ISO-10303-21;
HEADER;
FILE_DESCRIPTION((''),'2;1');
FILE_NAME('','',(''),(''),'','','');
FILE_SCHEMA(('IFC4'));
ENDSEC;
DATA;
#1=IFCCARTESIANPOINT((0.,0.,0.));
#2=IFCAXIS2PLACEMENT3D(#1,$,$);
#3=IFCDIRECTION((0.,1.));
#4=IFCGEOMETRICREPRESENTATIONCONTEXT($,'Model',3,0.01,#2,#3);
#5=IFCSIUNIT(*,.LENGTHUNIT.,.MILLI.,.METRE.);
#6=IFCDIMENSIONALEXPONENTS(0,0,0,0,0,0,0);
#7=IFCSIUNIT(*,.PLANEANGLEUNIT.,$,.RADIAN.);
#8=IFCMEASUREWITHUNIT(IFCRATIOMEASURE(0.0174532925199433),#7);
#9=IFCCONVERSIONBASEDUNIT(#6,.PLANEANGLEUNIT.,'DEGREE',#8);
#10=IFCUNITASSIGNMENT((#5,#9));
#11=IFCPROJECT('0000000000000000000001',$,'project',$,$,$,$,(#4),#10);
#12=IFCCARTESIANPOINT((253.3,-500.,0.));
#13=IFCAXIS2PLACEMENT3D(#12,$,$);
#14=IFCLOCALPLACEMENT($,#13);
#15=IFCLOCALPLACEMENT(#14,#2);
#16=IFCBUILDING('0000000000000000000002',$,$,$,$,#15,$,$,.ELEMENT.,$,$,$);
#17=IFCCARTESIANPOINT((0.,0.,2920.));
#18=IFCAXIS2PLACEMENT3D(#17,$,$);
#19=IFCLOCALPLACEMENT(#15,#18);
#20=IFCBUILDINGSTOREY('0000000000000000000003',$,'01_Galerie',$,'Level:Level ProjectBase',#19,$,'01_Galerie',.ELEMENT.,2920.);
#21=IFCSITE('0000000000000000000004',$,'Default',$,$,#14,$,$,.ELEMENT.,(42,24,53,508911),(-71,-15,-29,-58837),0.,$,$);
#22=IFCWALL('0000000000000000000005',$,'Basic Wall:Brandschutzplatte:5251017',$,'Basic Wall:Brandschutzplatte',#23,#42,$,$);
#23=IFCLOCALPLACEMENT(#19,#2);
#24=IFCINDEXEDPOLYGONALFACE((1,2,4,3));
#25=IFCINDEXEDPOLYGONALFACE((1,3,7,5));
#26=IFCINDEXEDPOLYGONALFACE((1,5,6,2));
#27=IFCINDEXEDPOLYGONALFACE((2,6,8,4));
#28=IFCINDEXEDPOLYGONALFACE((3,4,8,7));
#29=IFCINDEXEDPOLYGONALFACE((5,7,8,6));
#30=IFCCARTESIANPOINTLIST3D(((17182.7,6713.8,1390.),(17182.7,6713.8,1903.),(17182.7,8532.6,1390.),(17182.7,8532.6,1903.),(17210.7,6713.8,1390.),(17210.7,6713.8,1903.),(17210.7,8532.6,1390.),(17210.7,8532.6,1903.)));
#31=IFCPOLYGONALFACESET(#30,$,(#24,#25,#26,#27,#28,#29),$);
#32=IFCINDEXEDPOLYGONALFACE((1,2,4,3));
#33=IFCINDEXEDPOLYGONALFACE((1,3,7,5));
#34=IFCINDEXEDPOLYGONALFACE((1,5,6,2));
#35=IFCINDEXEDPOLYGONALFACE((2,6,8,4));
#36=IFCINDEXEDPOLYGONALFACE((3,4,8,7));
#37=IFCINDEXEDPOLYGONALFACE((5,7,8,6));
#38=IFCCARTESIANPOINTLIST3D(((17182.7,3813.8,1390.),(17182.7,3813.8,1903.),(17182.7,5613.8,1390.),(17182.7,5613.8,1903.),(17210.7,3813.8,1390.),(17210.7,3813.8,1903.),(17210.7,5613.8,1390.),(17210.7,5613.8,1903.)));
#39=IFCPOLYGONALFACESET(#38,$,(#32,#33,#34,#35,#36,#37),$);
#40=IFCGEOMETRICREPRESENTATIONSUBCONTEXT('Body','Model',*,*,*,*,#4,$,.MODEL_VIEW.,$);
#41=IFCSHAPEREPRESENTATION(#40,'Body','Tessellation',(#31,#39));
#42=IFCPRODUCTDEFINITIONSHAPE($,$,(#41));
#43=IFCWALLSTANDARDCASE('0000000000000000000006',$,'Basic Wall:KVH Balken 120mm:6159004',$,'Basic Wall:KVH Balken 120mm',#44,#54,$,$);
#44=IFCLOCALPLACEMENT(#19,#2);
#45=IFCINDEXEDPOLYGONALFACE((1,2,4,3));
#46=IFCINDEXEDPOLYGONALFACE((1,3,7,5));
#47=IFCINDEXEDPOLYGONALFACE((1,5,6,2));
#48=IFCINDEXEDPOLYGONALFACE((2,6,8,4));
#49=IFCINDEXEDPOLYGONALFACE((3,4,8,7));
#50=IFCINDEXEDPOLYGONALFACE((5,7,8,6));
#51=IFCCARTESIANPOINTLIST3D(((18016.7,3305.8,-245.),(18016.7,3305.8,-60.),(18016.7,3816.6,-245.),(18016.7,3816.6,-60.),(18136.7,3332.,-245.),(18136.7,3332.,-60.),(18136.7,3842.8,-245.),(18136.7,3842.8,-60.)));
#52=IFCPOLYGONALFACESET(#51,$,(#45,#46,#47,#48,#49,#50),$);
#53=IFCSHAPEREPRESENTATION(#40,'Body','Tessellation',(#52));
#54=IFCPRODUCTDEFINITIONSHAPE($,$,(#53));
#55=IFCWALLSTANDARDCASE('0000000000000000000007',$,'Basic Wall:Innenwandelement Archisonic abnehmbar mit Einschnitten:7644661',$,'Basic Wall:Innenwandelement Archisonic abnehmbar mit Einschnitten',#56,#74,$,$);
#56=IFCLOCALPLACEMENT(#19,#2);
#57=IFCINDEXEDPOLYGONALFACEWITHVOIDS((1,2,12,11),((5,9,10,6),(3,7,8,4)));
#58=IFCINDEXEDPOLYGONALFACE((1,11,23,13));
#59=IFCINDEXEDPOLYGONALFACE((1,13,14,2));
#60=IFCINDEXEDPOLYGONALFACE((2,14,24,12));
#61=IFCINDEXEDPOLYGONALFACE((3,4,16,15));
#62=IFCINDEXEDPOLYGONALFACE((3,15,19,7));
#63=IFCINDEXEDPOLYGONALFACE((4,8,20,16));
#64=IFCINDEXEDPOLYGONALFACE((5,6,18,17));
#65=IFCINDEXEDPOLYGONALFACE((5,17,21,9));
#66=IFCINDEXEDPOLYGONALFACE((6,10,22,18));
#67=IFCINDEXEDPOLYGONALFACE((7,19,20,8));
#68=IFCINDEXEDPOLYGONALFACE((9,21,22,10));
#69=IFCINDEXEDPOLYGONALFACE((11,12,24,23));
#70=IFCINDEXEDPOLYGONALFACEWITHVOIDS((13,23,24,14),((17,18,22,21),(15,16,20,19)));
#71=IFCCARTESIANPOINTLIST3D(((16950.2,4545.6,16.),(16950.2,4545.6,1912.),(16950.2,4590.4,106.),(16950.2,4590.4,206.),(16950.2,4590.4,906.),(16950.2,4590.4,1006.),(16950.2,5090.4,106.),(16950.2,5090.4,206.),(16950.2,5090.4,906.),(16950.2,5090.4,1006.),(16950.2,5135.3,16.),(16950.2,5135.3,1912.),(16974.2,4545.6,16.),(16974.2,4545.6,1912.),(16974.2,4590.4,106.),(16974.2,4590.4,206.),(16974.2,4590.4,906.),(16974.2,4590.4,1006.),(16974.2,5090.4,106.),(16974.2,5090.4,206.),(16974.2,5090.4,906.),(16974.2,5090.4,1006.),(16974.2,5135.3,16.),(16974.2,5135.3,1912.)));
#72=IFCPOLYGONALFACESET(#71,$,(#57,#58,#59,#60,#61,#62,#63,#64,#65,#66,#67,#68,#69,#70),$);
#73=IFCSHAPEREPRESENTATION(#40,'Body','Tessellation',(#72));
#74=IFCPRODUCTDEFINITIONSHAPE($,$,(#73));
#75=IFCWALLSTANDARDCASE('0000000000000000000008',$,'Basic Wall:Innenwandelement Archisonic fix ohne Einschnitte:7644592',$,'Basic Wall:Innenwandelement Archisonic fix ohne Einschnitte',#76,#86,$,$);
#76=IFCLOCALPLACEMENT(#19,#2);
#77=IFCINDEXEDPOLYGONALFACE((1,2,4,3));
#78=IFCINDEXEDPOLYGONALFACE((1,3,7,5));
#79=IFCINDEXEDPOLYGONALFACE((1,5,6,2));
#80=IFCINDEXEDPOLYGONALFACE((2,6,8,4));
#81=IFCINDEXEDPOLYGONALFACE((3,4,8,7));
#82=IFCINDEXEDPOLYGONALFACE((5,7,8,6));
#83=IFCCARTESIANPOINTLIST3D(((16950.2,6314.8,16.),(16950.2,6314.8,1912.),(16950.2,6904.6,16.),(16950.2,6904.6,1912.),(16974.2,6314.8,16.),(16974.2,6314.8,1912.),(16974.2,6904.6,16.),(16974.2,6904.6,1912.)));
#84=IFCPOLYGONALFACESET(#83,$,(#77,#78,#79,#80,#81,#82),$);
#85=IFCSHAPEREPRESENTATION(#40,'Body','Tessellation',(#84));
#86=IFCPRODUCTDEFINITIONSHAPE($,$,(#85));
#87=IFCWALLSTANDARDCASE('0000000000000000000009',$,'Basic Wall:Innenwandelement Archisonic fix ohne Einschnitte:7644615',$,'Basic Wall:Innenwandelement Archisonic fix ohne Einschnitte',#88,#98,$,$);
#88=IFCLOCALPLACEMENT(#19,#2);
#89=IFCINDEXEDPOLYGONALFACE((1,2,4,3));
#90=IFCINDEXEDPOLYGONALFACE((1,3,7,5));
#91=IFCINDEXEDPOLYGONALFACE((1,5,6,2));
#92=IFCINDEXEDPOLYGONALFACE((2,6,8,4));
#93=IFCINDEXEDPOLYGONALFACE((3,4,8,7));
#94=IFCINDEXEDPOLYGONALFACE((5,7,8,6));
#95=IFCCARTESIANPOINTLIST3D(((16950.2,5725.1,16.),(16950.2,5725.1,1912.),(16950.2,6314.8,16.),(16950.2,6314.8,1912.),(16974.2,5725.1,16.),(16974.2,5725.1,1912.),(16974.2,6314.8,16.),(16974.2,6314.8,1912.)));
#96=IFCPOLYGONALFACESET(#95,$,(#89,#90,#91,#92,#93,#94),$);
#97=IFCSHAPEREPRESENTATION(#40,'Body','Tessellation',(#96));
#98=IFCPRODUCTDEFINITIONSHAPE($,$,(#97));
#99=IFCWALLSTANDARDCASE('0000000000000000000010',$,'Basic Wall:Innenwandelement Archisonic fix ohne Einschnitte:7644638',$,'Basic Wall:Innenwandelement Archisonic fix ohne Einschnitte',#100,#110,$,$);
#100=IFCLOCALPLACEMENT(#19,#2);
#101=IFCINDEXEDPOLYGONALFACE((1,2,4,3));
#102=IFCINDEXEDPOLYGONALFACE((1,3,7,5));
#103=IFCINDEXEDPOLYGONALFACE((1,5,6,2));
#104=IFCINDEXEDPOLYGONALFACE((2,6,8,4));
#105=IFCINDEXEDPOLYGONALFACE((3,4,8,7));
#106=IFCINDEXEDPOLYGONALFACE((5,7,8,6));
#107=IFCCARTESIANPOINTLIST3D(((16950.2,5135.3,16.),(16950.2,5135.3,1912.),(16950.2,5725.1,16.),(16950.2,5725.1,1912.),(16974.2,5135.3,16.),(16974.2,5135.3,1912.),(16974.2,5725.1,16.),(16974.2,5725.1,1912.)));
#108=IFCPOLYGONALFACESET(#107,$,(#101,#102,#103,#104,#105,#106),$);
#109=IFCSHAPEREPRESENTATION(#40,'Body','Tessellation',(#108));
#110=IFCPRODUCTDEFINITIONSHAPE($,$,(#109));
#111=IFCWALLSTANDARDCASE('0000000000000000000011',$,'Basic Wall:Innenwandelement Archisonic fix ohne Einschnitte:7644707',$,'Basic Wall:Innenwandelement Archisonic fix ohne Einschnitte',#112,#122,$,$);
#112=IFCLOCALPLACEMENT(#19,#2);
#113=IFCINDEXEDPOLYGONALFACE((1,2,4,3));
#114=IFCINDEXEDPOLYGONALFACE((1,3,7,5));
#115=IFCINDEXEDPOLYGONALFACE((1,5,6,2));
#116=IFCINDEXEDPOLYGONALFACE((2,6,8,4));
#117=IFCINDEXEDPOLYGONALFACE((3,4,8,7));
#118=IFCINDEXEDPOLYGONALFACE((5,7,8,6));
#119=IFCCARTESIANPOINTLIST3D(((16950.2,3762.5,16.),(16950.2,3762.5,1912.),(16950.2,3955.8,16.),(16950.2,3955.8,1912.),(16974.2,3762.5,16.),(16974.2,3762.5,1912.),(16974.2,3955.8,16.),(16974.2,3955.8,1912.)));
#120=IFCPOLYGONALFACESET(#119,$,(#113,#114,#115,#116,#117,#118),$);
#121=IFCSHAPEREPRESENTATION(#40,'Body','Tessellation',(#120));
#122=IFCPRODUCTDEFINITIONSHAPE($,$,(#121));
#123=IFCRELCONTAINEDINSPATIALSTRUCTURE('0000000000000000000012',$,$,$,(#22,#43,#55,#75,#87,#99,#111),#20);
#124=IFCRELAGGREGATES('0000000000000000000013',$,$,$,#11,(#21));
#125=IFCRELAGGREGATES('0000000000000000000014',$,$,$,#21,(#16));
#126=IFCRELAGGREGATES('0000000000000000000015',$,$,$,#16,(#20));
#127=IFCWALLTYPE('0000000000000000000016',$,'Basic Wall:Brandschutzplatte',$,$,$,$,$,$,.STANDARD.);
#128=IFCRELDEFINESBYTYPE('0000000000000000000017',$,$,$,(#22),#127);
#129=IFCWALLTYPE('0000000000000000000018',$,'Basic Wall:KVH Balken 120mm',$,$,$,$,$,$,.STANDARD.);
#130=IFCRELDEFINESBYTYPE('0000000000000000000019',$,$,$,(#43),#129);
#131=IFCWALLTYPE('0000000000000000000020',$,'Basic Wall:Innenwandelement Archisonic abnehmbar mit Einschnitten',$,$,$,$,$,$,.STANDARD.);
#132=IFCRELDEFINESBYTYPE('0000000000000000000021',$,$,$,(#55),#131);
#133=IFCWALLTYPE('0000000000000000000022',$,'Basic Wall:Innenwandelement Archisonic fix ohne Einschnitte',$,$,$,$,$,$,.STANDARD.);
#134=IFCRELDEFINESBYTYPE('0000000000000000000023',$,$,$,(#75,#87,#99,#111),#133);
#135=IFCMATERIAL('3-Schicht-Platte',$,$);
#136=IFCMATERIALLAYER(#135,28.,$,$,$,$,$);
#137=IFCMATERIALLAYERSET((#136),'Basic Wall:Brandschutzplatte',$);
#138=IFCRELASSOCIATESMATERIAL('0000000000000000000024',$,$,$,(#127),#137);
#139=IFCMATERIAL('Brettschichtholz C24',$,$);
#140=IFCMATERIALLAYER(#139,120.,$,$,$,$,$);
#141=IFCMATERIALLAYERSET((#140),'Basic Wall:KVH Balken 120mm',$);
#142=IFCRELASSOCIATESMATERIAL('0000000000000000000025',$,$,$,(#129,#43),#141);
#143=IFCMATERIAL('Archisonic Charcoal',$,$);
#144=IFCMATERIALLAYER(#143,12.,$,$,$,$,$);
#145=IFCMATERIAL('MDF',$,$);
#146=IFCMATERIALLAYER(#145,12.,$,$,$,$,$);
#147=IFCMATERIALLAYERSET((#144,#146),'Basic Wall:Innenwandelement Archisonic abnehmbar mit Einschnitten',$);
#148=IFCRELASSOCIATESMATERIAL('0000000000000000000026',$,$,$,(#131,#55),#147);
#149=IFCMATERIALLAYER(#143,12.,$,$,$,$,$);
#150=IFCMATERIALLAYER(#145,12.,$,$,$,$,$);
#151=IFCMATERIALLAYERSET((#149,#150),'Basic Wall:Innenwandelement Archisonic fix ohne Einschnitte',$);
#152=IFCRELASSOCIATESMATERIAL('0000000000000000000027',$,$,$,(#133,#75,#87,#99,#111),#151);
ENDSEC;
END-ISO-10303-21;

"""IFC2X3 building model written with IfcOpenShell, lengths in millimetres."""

from ifc_helpers import new_model, entity, si_unit, converted_unit, direction, frame, frame_2d, origin, place, context, subcontext, project, spatial, polyline, rectangle, outline, extrude, clip, bounded_halfspace, material, layer, layer_set, layer_usage, type_object, element, save


model = new_model("IFC2X3")

# Units and contexts
model_context = context("Model", 3, precision=0.01, world=origin(), true_north=direction((0.0, 1.0)))
body_context = subcontext(model_context, "Body", "Model", "MODEL_VIEW")
ifc_project = project(units=[si_unit("LENGTHUNIT", "METRE", prefix="MILLI"), converted_unit("PLANEANGLEUNIT", "DEGREE", entity("IfcRatioMeasure", 0.0174532925199433), si_unit("PLANEANGLEUNIT", "RADIAN"), dimensions=[0, 0, 0, 0, 0, 0, 0])], contexts=[model_context])

# Site, building, storey
site_placement = place(None, frame((253.3, -500.0, 0.0)))
site = spatial("IfcSite", under=ifc_project, at=site_placement, Name="Default", CompositionType="ELEMENT", RefLatitude=(42, 24, 53, 508911), RefLongitude=(-71, -15, -29, -58837), RefElevation=0.0)
building_placement = place(site_placement, origin())
building = spatial("IfcBuilding", under=site, at=building_placement, CompositionType="ELEMENT")
storey_placement = place(building_placement, frame((0.0, 0.0, 2920.0)))
storey = spatial("IfcBuildingStorey", under=building, at=storey_placement, Name="01_Galerie", ObjectType="Level:Level ProjectBase", LongName="01_Galerie", CompositionType="ELEMENT", Elevation=2920.0)

# Shared definitions
ifc_material_1 = material(Name="Archisonic Charcoal")
ifc_material_2 = material(Name="MDF")
ifc_material_3 = material(Name="Brettschichtholz C24")

# Walls
ifc_material_4 = material(Name="3-Schicht-Platte")
ifc_layer_1 = layer(ifc_material_4, 28.0)
ifc_layer_set_1 = layer_set([ifc_layer_1], Name="Basic Wall:Brandschutzplatte")
wall_type_1 = type_object("IfcWallType", Name="Basic Wall:Brandschutzplatte", PredefinedType="STANDARD", material=ifc_layer_set_1)
wall_1_placement = place(storey_placement, frame((17196.7, 3813.8, 1390.0), z_axis=(0.0, 0.0, 1.0), x_axis=(0.0, 1.0, 0.0)))
element("IfcWall", 1, at=wall_1_placement, inside=storey, type_object=wall_type_1, Name="Basic Wall:Brandschutzplatte:5251017", ObjectType="Basic Wall:Brandschutzplatte", context=body_context, shape_type="SweptSolid", body=[
    extrude(rectangle(XDim=28.0, YDim=1818.8, at=frame_2d((0.0, 0.0), x_axis=(1.0, 0.0))), frame((3809.4, 0.0, 0.0), z_axis=(0.0, 0.0, 1.0), x_axis=(0.0, 1.0, 0.0)), (0.0, 0.0, 1.0), 513.0),
    extrude(rectangle(XDim=28.0, YDim=1800.0, at=frame_2d((0.0, 0.0), x_axis=(1.0, 0.0))), frame((900.0, 0.0, 0.0), z_axis=(0.0, 0.0, 1.0), x_axis=(0.0, 1.0, 0.0)), (0.0, 0.0, 1.0), 513.0),
])
ifc_layer_2 = layer(ifc_material_3, 120.0)
ifc_layer_set_2 = layer_set([ifc_layer_2], Name="Basic Wall:KVH Balken 120mm")
ifc_layer_usage_1 = layer_usage(ifc_layer_set_2, "AXIS2", "NEGATIVE", 60.0)
wall_type_2 = type_object("IfcWallType", Name="Basic Wall:KVH Balken 120mm", PredefinedType="STANDARD", material=ifc_layer_set_2)
wall_2_placement = place(storey_placement, frame((18076.7, 3305.8, -245.0), z_axis=(0.0, 0.0, 1.0), x_axis=(0.0, 1.0, 0.0)))
element("IfcWallStandardCase", 2, at=wall_2_placement, inside=storey, type_object=wall_type_2, material=ifc_layer_usage_1, Name="Basic Wall:KVH Balken 120mm:6159004", ObjectType="Basic Wall:KVH Balken 120mm", context=body_context, shape_type="Clipping", body=[
    clip(extrude(outline(polyline([(537.0, -60.0), (510.8, 60.0), (0.0, 60.0), (26.2, -60.0), (537.0, -60.0)])), origin(), (0.0, 0.0, 1.0), 185.0), bounded_halfspace(frame((537.0, -60.0, 185.0), z_axis=(-0.977008, -0.213201, 0.0), x_axis=(0.213201, -0.977008, 0.0)), True, frame((537.0, -60.0, 185.0), z_axis=(-0.977008, -0.213201, 0.0), x_axis=(0.213201, -0.977008, 0.0)), polyline([(0.0, 0.0), (-122.8, 0.0), (-122.8, -185.0), (0.0, -185.0), (0.0, 0.0)]))),
])

# Wall, openings
ifc_layer_3 = layer(ifc_material_1, 12.0)
ifc_layer_4 = layer(ifc_material_2, 12.0)
ifc_layer_set_3 = layer_set([ifc_layer_3, ifc_layer_4], Name="Basic Wall:Innenwandelement Archisonic abnehmbar mit Einschnitten")
ifc_layer_usage_2 = layer_usage(ifc_layer_set_3, "AXIS2", "POSITIVE", -12.0)
wall_type_3 = type_object("IfcWallType", Name="Basic Wall:Innenwandelement Archisonic abnehmbar mit Einschnitten", PredefinedType="STANDARD", material=ifc_layer_set_3)
wall_3_placement = place(storey_placement, frame((16962.2, 5135.3, 16.0), z_axis=(0.0, 0.0, 1.0), x_axis=(0.0, -1.0, 0.0)))
wall_3 = element("IfcWallStandardCase", 3, at=wall_3_placement, inside=storey, type_object=wall_type_3, material=ifc_layer_usage_2, Name="Basic Wall:Innenwandelement Archisonic abnehmbar mit Einschnitten:7644661", ObjectType="Basic Wall:Innenwandelement Archisonic abnehmbar mit Einschnitten", context=body_context, shape_type="SweptSolid", body=[
    extrude(rectangle(XDim=589.8, YDim=24.0, at=frame_2d((294.9, 0.0), x_axis=(-1.0, 0.0))), origin(), (0.0, 0.0, 1.0), 1896.0),
])
opening_1_placement = place(wall_3_placement, frame((544.9, -45.8, 890.0)))
element("IfcOpeningElement", 4, at=opening_1_placement, cuts=wall_3, ObjectType="Opening", context=body_context, shape_type="SweptSolid", body=[
    extrude(rectangle(XDim=100.0, YDim=500.0, at=frame_2d((0.0, 0.0), x_axis=(0.0, 1.0))), frame((-250.0, 0.0, 50.0), z_axis=(0.0, 1.0, 0.0), x_axis=(-1.0, 0.0, 0.0)), (0.0, 0.0, 1.0), 336.7),
])
opening_2_placement = place(wall_3_placement, frame((544.9, -45.8, 90.0)))
element("IfcOpeningElement", 5, at=opening_2_placement, cuts=wall_3, ObjectType="Opening", context=body_context, shape_type="SweptSolid", body=[
    extrude(rectangle(XDim=100.0, YDim=500.0, at=frame_2d((0.0, 0.0), x_axis=(0.0, 1.0))), frame((-250.0, 0.0, 50.0), z_axis=(0.0, 1.0, 0.0), x_axis=(-1.0, 0.0, 0.0)), (0.0, 0.0, 1.0), 136.7),
])

# Walls
ifc_layer_5 = layer(ifc_material_1, 12.0)
ifc_layer_6 = layer(ifc_material_2, 12.0)
ifc_layer_set_4 = layer_set([ifc_layer_5, ifc_layer_6], Name="Basic Wall:Innenwandelement Archisonic fix ohne Einschnitte")
ifc_layer_usage_3 = layer_usage(ifc_layer_set_4, "AXIS2", "POSITIVE", -12.0)
wall_type_4 = type_object("IfcWallType", Name="Basic Wall:Innenwandelement Archisonic fix ohne Einschnitte", PredefinedType="STANDARD", material=ifc_layer_set_4)
wall_4_placement = place(storey_placement, frame((16962.2, 6904.6, 16.0), z_axis=(0.0, 0.0, 1.0), x_axis=(0.0, -1.0, 0.0)))
element("IfcWallStandardCase", 6, at=wall_4_placement, inside=storey, type_object=wall_type_4, material=ifc_layer_usage_3, Name="Basic Wall:Innenwandelement Archisonic fix ohne Einschnitte:7644592", ObjectType="Basic Wall:Innenwandelement Archisonic fix ohne Einschnitte", context=body_context, shape_type="SweptSolid", body=[
    extrude(rectangle(XDim=589.8, YDim=24.0, at=frame_2d((294.9, 0.0), x_axis=(-1.0, 0.0))), origin(), (0.0, 0.0, 1.0), 1896.0),
])
ifc_layer_usage_4 = layer_usage(ifc_layer_set_4, "AXIS2", "POSITIVE", -12.0)
wall_5_placement = place(storey_placement, frame((16962.2, 6314.8, 16.0), z_axis=(0.0, 0.0, 1.0), x_axis=(0.0, -1.0, 0.0)))
element("IfcWallStandardCase", 7, at=wall_5_placement, inside=storey, type_object=wall_type_4, material=ifc_layer_usage_4, Name="Basic Wall:Innenwandelement Archisonic fix ohne Einschnitte:7644615", ObjectType="Basic Wall:Innenwandelement Archisonic fix ohne Einschnitte", context=body_context, shape_type="SweptSolid", body=[
    extrude(rectangle(XDim=589.8, YDim=24.0, at=frame_2d((294.9, 0.0), x_axis=(-1.0, 0.0))), origin(), (0.0, 0.0, 1.0), 1896.0),
])
ifc_layer_usage_5 = layer_usage(ifc_layer_set_4, "AXIS2", "POSITIVE", -12.0)
wall_6_placement = place(storey_placement, frame((16962.2, 5725.1, 16.0), z_axis=(0.0, 0.0, 1.0), x_axis=(0.0, -1.0, 0.0)))
element("IfcWallStandardCase", 8, at=wall_6_placement, inside=storey, type_object=wall_type_4, material=ifc_layer_usage_5, Name="Basic Wall:Innenwandelement Archisonic fix ohne Einschnitte:7644638", ObjectType="Basic Wall:Innenwandelement Archisonic fix ohne Einschnitte", context=body_context, shape_type="SweptSolid", body=[
    extrude(rectangle(XDim=589.8, YDim=24.0, at=frame_2d((294.9, 0.0), x_axis=(-1.0, 0.0))), origin(), (0.0, 0.0, 1.0), 1896.0),
])
ifc_layer_usage_6 = layer_usage(ifc_layer_set_4, "AXIS2", "POSITIVE", -12.0)
wall_7_placement = place(storey_placement, frame((16962.2, 3955.8, 16.0), z_axis=(0.0, 0.0, 1.0), x_axis=(0.0, -1.0, 0.0)))
element("IfcWallStandardCase", 9, at=wall_7_placement, inside=storey, type_object=wall_type_4, material=ifc_layer_usage_6, Name="Basic Wall:Innenwandelement Archisonic fix ohne Einschnitte:7644707", ObjectType="Basic Wall:Innenwandelement Archisonic fix ohne Einschnitte", context=body_context, shape_type="SweptSolid", body=[
    extrude(rectangle(XDim=193.3, YDim=24.0, at=frame_2d((96.6, 0.0), x_axis=(-1.0, 0.0))), origin(), (0.0, 0.0, 1.0), 1896.0),
])

save(model, "model.ifc")
